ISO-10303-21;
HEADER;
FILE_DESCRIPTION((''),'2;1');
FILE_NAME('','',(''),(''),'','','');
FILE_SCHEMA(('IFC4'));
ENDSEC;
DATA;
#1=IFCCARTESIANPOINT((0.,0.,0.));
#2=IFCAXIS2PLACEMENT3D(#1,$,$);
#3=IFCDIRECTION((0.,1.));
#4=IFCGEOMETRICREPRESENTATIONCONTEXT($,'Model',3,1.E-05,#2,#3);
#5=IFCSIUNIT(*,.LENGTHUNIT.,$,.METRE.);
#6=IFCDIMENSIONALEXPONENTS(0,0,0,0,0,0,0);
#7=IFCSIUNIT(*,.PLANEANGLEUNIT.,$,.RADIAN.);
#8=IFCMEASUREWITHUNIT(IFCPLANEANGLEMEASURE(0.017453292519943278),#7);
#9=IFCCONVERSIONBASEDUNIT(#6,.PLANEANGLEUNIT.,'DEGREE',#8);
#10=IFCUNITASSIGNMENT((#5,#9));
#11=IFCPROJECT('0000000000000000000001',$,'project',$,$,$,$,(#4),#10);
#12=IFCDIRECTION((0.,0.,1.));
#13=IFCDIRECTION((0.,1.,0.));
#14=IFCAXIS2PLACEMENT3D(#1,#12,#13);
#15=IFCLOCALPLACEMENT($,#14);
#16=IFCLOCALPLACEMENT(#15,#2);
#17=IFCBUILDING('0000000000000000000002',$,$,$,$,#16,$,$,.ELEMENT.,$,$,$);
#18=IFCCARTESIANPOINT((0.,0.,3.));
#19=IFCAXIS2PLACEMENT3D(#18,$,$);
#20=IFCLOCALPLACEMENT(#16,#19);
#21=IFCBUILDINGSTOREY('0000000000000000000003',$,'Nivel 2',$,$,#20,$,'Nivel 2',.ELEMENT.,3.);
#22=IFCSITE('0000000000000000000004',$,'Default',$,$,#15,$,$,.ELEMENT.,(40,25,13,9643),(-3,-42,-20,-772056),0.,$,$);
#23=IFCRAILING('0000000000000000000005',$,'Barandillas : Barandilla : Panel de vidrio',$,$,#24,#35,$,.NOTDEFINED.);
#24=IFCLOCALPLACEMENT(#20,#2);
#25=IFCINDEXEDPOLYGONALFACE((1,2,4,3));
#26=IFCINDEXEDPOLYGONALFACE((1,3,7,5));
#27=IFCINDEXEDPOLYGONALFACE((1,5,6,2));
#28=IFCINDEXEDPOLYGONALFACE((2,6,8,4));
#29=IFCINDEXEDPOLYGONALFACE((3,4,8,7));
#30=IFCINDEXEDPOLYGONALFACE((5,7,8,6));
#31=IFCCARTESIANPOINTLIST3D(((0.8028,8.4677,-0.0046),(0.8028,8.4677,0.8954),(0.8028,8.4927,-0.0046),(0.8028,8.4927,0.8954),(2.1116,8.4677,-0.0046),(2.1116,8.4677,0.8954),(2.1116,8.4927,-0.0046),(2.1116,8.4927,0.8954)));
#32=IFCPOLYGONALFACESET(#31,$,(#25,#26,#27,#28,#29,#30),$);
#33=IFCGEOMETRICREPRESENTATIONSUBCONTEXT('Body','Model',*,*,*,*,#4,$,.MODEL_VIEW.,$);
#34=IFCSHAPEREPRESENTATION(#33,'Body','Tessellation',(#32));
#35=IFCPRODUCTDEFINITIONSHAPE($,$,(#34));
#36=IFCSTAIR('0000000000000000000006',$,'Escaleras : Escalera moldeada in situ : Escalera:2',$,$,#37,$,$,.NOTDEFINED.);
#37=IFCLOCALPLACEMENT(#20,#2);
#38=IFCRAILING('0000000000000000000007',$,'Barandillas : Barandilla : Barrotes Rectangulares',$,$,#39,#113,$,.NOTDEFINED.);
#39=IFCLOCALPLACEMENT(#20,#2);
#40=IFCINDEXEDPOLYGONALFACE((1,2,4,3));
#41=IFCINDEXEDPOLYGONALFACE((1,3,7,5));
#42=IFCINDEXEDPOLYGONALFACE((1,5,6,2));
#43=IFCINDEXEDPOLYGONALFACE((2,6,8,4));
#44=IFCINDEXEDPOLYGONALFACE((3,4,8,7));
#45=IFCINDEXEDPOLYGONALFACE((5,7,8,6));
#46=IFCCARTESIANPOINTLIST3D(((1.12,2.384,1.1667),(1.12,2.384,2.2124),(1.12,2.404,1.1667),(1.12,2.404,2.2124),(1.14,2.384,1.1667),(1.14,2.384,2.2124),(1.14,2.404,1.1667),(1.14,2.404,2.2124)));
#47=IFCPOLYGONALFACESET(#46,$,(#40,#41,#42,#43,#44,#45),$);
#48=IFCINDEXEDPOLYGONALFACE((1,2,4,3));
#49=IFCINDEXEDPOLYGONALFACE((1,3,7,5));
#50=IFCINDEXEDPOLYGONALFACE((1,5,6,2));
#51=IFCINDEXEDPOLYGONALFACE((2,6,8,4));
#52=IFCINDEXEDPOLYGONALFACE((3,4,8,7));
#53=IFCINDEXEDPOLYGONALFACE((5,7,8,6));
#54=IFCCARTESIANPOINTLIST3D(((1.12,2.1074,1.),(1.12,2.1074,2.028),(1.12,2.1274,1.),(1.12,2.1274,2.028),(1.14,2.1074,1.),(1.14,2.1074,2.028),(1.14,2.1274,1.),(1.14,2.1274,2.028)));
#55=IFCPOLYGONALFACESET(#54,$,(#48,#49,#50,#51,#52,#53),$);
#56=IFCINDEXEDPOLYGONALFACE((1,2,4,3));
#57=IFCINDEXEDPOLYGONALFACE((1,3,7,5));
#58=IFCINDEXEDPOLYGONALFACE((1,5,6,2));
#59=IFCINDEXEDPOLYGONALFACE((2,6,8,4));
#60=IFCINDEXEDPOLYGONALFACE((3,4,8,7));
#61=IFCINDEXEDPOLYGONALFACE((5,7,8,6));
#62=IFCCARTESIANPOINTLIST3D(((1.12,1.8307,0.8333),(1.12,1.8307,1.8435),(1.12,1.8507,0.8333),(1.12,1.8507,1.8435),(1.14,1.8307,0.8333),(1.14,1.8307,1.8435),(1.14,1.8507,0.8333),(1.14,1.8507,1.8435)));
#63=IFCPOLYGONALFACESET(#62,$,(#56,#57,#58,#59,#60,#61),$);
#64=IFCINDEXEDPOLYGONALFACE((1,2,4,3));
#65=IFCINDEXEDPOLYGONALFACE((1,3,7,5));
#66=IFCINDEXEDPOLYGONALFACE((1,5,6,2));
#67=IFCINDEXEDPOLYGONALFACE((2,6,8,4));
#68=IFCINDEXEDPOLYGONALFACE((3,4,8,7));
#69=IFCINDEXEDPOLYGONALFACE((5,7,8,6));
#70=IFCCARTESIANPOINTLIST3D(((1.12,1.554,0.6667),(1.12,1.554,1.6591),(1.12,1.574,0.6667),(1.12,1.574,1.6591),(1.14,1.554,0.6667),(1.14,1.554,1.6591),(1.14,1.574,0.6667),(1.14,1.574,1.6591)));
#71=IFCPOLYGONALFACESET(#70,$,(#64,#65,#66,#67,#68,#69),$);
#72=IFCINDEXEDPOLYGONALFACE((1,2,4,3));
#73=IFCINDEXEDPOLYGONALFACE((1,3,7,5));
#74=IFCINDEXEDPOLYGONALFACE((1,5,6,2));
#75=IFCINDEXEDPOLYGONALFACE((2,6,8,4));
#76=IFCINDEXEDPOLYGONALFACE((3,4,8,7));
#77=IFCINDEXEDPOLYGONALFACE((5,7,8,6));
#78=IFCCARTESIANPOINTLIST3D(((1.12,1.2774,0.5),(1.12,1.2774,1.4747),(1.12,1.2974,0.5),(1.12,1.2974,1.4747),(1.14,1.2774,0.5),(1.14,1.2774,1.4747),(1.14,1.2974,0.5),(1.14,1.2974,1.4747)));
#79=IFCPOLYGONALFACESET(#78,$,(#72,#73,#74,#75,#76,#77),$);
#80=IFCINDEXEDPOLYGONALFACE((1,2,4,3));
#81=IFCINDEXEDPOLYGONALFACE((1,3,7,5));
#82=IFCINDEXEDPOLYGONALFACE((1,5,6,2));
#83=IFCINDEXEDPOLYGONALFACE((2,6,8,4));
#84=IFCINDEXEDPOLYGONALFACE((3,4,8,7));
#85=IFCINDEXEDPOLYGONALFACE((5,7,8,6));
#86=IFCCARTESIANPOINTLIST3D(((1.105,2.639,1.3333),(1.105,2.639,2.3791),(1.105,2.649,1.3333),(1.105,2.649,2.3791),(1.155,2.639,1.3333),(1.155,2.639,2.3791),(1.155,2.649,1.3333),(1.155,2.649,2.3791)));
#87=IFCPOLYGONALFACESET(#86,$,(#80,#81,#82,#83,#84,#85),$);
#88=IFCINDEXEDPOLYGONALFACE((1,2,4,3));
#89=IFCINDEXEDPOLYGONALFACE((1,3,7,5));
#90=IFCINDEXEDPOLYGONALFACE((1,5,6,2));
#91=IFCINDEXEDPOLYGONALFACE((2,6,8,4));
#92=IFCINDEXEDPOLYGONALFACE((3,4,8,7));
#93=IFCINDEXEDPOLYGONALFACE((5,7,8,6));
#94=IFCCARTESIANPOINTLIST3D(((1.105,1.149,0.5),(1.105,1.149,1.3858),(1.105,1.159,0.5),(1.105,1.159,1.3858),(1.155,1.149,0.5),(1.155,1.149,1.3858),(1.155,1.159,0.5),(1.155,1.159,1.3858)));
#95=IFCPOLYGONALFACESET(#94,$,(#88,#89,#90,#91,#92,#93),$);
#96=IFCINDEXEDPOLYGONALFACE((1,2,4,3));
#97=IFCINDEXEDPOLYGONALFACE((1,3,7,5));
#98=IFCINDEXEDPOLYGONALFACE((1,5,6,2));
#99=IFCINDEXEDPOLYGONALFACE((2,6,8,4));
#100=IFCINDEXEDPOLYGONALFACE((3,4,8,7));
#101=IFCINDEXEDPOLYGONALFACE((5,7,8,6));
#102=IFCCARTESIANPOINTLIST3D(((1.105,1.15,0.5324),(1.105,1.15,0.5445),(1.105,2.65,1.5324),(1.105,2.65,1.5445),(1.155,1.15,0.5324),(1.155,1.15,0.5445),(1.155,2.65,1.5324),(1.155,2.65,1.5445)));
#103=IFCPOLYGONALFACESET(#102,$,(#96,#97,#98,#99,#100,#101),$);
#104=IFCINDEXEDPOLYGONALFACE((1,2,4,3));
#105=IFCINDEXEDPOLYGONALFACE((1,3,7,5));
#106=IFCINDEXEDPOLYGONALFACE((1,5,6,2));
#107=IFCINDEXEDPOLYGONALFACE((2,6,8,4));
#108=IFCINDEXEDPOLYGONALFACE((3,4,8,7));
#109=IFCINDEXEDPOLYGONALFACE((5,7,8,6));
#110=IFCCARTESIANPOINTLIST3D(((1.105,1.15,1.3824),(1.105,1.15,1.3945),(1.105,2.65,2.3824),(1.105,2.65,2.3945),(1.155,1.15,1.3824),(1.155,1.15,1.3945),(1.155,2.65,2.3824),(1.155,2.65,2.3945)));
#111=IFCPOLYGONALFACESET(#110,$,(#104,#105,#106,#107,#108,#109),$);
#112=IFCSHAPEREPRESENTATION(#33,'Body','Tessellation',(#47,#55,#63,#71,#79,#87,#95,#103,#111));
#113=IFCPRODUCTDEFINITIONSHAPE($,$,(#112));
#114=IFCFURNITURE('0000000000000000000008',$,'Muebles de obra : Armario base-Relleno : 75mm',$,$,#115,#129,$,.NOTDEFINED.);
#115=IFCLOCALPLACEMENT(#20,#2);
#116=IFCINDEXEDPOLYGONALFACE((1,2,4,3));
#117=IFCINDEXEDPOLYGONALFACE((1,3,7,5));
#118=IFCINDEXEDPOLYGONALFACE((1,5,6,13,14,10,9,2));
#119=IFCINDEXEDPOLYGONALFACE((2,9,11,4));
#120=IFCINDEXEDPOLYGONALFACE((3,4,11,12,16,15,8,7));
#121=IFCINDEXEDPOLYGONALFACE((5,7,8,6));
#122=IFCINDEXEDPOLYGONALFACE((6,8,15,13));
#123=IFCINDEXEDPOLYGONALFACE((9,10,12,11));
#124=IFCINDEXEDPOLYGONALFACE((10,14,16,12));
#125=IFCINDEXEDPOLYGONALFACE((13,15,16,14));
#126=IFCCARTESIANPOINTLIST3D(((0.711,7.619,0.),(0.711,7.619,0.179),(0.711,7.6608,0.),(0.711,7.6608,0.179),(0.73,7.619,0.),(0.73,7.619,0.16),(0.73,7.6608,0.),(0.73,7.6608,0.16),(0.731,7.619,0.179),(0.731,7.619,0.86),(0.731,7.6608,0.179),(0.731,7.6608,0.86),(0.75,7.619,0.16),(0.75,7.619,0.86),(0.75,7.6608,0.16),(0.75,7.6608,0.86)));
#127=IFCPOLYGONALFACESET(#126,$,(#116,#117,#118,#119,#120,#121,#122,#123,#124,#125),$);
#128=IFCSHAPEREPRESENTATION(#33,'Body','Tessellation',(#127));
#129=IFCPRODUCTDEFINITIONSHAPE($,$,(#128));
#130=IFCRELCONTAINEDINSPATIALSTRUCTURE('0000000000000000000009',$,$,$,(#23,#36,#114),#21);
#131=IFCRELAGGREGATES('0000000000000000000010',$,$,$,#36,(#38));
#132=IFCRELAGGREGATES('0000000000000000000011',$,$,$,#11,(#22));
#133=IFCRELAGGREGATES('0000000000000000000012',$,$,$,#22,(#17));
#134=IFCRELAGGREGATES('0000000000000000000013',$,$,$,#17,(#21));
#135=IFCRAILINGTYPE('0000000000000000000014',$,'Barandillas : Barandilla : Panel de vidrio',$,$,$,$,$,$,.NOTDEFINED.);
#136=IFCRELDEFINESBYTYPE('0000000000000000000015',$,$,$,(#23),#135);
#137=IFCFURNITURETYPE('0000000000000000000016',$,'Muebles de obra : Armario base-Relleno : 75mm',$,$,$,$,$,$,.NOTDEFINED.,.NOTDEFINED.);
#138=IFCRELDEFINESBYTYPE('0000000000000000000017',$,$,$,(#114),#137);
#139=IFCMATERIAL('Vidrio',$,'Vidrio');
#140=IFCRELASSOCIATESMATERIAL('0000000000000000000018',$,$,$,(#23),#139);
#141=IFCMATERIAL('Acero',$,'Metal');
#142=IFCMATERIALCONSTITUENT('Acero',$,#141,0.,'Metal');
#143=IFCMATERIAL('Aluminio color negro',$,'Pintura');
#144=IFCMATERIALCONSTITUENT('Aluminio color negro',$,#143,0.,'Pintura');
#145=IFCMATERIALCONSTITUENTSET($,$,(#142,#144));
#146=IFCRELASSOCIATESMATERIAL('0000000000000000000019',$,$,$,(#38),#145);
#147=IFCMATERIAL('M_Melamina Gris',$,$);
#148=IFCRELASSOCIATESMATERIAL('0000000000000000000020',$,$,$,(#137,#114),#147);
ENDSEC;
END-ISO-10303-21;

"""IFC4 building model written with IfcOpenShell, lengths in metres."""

from ifc_helpers import new_model, entity, si_unit, converted_unit, direction, frame, origin, place, context, subcontext, project, spatial, indexed_curve, outline, extrude, source, transform, mapped, material, constituent, constituent_set, type_object, type_shapes, element, aggregate, save


model = new_model("IFC4")

# Units and contexts
model_context = context("Model", 3, precision=1e-05, world=origin(), true_north=direction((0.0, 1.0)))
body_context = subcontext(model_context, "Body", "Model", "MODEL_VIEW")
ifc_project = project(units=[si_unit("LENGTHUNIT", "METRE"), converted_unit("PLANEANGLEUNIT", "DEGREE", entity("IfcPlaneAngleMeasure", 0.017453292519943278), si_unit("PLANEANGLEUNIT", "RADIAN"), dimensions=[0, 0, 0, 0, 0, 0, 0])], contexts=[model_context])

# Site, building, storey
site_placement = place(None, frame((0.0, 0.0, 0.0), z_axis=(0.0, 0.0, 1.0), x_axis=(0.0, 1.0, 0.0)))
site = spatial("IfcSite", under=ifc_project, at=site_placement, Name="Default", CompositionType="ELEMENT", RefLatitude=(40, 25, 13, 9643), RefLongitude=(-3, -42, -20, -772056), RefElevation=0.0)
building_placement = place(site_placement, origin())
building = spatial("IfcBuilding", under=site, at=building_placement, CompositionType="ELEMENT")
storey_placement = place(building_placement, frame((0.0, 0.0, 3.0)))
storey = spatial("IfcBuildingStorey", under=building, at=storey_placement, Name="Nivel 2", LongName="Nivel 2", CompositionType="ELEMENT", Elevation=3.0)

# Shared definitions
ifc_material_1 = material(Name="Vidrio", Category="Vidrio")

# Railing
railing_type = type_object("IfcRailingType", Name="Barandillas : Barandilla : Panel de vidrio", PredefinedType="NOTDEFINED")
railing_1_placement = place(storey_placement, origin())
element("IfcRailing", 1, at=railing_1_placement, inside=storey, type_object=railing_type, material=ifc_material_1, Name="Barandillas : Barandilla : Panel de vidrio", PredefinedType="NOTDEFINED", context=body_context, shape_type="SweptSolid", body=[
    extrude(outline(indexed_curve([(-0.6544, -0.0125), (0.6544, -0.0125), (0.6544, 0.0125), (-0.6544, 0.0125), (-0.6544, -0.0125)], self_intersect=False)), frame((1.4572, 8.4802, -0.0046)), (0.0, 0.0, 1.0), 0.9),
])

# Stair, railing
stair_placement = place(storey_placement, origin())
stair = element("IfcStair", 2, at=stair_placement, inside=storey, Name="Escaleras : Escalera moldeada in situ : Escalera:2", PredefinedType="NOTDEFINED")
ifc_material_2 = material(Name="Acero", Category="Metal")
ifc_constituent_1 = constituent(ifc_material_2, Name="Acero", Category="Metal", fraction=0.0)
ifc_material_3 = material(Name="Aluminio color negro", Category="Pintura")
ifc_constituent_2 = constituent(ifc_material_3, Name="Aluminio color negro", Category="Pintura", fraction=0.0)
ifc_constituent_set = constituent_set(constituents=[ifc_constituent_1, ifc_constituent_2])
railing_2_placement = place(stair_placement, origin())
railing_2 = element("IfcRailing", 3, at=railing_2_placement, material=ifc_constituent_set, Name="Barandillas : Barandilla : Barrotes Rectangulares", PredefinedType="NOTDEFINED", context=body_context, shape_type="SweptSolid", body=[
    extrude(outline(indexed_curve([(-0.01, -0.01), (0.01, -0.01), (0.01, 0.01), (-0.01, 0.01), (-0.01, -0.01)], self_intersect=False)), frame((1.13, 2.394, 1.1667)), (0.0, 0.0, 1.0), 1.0458),
    extrude(outline(indexed_curve([(-0.01, -0.01), (0.01, -0.01), (0.01, 0.01), (-0.01, 0.01), (-0.01, -0.01)], self_intersect=False)), frame((1.13, 2.1174, 1.0)), (0.0, 0.0, 1.0), 1.028),
    extrude(outline(indexed_curve([(-0.01, -0.01), (0.01, -0.01), (0.01, 0.01), (-0.01, 0.01), (-0.01, -0.01)], self_intersect=False)), frame((1.13, 1.8407, 0.8333)), (0.0, 0.0, 1.0), 1.0102),
    extrude(outline(indexed_curve([(-0.01, -0.01), (0.01, -0.01), (0.01, 0.01), (-0.01, 0.01), (-0.01, -0.01)], self_intersect=False)), frame((1.13, 1.564, 0.6667)), (0.0, 0.0, 1.0), 0.9924),
    extrude(outline(indexed_curve([(-0.01, -0.01), (0.01, -0.01), (0.01, 0.01), (-0.01, 0.01), (-0.01, -0.01)], self_intersect=False)), frame((1.13, 1.2874, 0.5)), (0.0, 0.0, 1.0), 0.9747),
    extrude(outline(indexed_curve([(-0.025, -0.005), (0.025, -0.005), (0.025, 0.005), (-0.025, 0.005), (-0.025, -0.005)], self_intersect=False)), frame((1.13, 2.644, 1.3333)), (0.0, 0.0, 1.0), 1.0458),
    extrude(outline(indexed_curve([(-0.025, -0.005), (0.025, -0.005), (0.025, 0.005), (-0.025, 0.005), (-0.025, -0.005)], self_intersect=False)), frame((1.13, 1.154, 0.5)), (0.0, 0.0, 1.0), 0.8858),
    extrude(outline(indexed_curve([(-0.9047, -0.005), (0.8981, -0.005), (0.9047, 0.005), (-0.8981, 0.005), (-0.9047, -0.005)], self_intersect=False)), frame((1.105, 1.9, 1.0384), z_axis=(1.0, 0.0, 0.0), x_axis=(0.0, 0.83205, 0.5547)), (0.0, 0.0, 1.0), 0.05),
    extrude(outline(indexed_curve([(-0.9047, -0.005), (0.8981, -0.005), (0.9047, 0.005), (-0.8981, 0.005), (-0.9047, -0.005)], self_intersect=False)), frame((1.105, 1.9, 1.8884), z_axis=(1.0, 0.0, 0.0), x_axis=(0.0, 0.83205, 0.5547)), (0.0, 0.0, 1.0), 0.05),
])
aggregate(stair, [railing_2])

# Furniture
ifc_material_4 = material(Name="M_Melamina Gris")
furniture_type_1 = type_object("IfcFurnitureType", Name="Muebles de obra : Armario base-Relleno : 75mm", AssemblyPlace="NOTDEFINED", PredefinedType="NOTDEFINED", material=ifc_material_4)
shared_shape_1 = source(origin(), body_context, "Body", "SweptSolid", [
    extrude(outline(indexed_curve([(-0.0195, 0.1398), (-0.0195, -0.5602), (-0.0005, -0.5602), (-0.0005, 0.1207), (0.0195, 0.1207), (0.0195, 0.2998), (0.0005, 0.2998), (0.0005, 0.1398), (-0.0195, 0.1398)], self_intersect=False)), frame((0.7305, 7.619, 3.2998), z_axis=(0.0, -1.0, 0.0), x_axis=(-1.0, 0.0, 0.0)), (0.0, 0.0, -1.0), 0.0418),
])
type_shapes(furniture_type_1, [shared_shape_1])
furniture_1_placement = place(storey_placement, frame((0.0, 0.0, -3.0)))
element("IfcFurniture", 4, at=furniture_1_placement, inside=storey, type_object=furniture_type_1, material=ifc_material_4, Name="Muebles de obra : Armario base-Relleno : 75mm", PredefinedType="NOTDEFINED", context=body_context, shape_type="MappedRepresentation", body=[
    mapped(shared_shape_1, transform((0.0, 0.0, 0.0), scale=1.0)),
])

save(model, "model.ifc")
